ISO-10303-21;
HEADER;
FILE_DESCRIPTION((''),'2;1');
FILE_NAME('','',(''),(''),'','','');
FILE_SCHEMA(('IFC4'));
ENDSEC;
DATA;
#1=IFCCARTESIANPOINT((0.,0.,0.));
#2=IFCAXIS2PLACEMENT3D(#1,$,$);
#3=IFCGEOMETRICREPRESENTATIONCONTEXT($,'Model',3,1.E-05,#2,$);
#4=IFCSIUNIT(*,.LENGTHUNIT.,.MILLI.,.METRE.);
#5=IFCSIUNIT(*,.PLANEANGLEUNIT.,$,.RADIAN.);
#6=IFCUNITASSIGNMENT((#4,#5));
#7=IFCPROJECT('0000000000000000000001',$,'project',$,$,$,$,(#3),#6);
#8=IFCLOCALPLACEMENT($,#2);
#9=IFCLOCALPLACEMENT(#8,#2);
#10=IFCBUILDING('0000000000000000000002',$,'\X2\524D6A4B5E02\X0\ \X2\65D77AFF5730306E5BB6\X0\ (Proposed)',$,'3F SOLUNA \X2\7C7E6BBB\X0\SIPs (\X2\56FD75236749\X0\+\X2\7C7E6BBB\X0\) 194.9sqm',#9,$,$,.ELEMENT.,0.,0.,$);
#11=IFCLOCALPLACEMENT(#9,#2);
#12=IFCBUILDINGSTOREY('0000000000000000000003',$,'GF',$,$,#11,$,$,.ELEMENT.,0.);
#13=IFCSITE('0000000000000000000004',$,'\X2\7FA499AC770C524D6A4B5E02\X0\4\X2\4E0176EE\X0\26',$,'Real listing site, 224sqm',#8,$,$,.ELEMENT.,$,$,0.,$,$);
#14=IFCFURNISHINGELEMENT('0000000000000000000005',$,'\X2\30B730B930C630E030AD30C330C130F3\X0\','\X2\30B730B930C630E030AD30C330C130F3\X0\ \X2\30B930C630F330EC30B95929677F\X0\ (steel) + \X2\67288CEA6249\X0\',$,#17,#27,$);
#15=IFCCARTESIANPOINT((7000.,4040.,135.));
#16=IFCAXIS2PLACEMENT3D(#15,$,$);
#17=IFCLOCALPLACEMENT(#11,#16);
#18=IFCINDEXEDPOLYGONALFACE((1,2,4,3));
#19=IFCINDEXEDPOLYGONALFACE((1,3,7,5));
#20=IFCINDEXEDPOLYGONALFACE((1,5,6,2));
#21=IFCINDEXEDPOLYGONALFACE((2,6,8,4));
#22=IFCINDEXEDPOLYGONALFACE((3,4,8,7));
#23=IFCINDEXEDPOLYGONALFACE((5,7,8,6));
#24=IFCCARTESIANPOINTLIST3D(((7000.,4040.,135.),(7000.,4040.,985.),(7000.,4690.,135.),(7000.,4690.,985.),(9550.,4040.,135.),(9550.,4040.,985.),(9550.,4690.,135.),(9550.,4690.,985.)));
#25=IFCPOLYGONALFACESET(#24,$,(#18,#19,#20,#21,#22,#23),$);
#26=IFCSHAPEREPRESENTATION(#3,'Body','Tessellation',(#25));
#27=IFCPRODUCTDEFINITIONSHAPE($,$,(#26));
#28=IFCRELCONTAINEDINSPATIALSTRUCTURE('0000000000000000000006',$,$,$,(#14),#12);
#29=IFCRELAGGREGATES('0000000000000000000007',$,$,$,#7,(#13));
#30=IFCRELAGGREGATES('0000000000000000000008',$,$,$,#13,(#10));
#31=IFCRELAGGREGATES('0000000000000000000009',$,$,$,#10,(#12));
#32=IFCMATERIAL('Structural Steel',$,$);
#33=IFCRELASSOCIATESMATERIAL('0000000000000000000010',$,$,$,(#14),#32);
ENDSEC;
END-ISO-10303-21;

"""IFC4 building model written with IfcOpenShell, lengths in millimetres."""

from ifc_helpers import new_model, si_unit, frame, frame_2d, origin, place, context, project, spatial, rectangle, extrude, material, element, save


model = new_model("IFC4")

# Units and contexts
model_context = context("Model", 3, precision=1e-05, world=origin())
ifc_project = project(units=[si_unit("LENGTHUNIT", "METRE", prefix="MILLI"), si_unit("PLANEANGLEUNIT", "RADIAN")], contexts=[model_context])

# Site, building, storey
site_placement = place(None, origin())
site = spatial("IfcSite", under=ifc_project, at=site_placement, Name="群馬県前橋市4丁目26", ObjectType="Real listing site, 224sqm", CompositionType="ELEMENT", RefElevation=0.0)
building_placement = place(site_placement, origin())
building = spatial("IfcBuilding", under=site, at=building_placement, Name="前橋市 旗竿地の家 (Proposed)", ObjectType="3F SOLUNA 籾殻SIPs (国産杉+籾殻) 194.9sqm", CompositionType="ELEMENT", ElevationOfRefHeight=0.0, ElevationOfTerrain=0.0)
storey_placement = place(building_placement, origin())
storey = spatial("IfcBuildingStorey", under=building, at=storey_placement, Name="GF", CompositionType="ELEMENT", Elevation=0.0)

# Furnishing element
ifc_material_1 = material(Name="Structural Steel")
furnishing_1_placement = place(storey_placement, frame((7000.0, 4040.0, 135.0)))
element("IfcFurnishingElement", 1, at=furnishing_1_placement, inside=storey, material=ifc_material_1, Name="システムキッチン", Description="システムキッチン ステンレス天板 (steel) + 木質扉", context=model_context, shape_type="SweptSolid", body=[
    extrude(rectangle(XDim=2550.0, YDim=650.0, at=frame_2d((1275.0, 325.0))), frame((7000.0, 4040.0, 135.0)), (0.0, 0.0, 1.0), 850.0),
])

save(model, "model.ifc")
